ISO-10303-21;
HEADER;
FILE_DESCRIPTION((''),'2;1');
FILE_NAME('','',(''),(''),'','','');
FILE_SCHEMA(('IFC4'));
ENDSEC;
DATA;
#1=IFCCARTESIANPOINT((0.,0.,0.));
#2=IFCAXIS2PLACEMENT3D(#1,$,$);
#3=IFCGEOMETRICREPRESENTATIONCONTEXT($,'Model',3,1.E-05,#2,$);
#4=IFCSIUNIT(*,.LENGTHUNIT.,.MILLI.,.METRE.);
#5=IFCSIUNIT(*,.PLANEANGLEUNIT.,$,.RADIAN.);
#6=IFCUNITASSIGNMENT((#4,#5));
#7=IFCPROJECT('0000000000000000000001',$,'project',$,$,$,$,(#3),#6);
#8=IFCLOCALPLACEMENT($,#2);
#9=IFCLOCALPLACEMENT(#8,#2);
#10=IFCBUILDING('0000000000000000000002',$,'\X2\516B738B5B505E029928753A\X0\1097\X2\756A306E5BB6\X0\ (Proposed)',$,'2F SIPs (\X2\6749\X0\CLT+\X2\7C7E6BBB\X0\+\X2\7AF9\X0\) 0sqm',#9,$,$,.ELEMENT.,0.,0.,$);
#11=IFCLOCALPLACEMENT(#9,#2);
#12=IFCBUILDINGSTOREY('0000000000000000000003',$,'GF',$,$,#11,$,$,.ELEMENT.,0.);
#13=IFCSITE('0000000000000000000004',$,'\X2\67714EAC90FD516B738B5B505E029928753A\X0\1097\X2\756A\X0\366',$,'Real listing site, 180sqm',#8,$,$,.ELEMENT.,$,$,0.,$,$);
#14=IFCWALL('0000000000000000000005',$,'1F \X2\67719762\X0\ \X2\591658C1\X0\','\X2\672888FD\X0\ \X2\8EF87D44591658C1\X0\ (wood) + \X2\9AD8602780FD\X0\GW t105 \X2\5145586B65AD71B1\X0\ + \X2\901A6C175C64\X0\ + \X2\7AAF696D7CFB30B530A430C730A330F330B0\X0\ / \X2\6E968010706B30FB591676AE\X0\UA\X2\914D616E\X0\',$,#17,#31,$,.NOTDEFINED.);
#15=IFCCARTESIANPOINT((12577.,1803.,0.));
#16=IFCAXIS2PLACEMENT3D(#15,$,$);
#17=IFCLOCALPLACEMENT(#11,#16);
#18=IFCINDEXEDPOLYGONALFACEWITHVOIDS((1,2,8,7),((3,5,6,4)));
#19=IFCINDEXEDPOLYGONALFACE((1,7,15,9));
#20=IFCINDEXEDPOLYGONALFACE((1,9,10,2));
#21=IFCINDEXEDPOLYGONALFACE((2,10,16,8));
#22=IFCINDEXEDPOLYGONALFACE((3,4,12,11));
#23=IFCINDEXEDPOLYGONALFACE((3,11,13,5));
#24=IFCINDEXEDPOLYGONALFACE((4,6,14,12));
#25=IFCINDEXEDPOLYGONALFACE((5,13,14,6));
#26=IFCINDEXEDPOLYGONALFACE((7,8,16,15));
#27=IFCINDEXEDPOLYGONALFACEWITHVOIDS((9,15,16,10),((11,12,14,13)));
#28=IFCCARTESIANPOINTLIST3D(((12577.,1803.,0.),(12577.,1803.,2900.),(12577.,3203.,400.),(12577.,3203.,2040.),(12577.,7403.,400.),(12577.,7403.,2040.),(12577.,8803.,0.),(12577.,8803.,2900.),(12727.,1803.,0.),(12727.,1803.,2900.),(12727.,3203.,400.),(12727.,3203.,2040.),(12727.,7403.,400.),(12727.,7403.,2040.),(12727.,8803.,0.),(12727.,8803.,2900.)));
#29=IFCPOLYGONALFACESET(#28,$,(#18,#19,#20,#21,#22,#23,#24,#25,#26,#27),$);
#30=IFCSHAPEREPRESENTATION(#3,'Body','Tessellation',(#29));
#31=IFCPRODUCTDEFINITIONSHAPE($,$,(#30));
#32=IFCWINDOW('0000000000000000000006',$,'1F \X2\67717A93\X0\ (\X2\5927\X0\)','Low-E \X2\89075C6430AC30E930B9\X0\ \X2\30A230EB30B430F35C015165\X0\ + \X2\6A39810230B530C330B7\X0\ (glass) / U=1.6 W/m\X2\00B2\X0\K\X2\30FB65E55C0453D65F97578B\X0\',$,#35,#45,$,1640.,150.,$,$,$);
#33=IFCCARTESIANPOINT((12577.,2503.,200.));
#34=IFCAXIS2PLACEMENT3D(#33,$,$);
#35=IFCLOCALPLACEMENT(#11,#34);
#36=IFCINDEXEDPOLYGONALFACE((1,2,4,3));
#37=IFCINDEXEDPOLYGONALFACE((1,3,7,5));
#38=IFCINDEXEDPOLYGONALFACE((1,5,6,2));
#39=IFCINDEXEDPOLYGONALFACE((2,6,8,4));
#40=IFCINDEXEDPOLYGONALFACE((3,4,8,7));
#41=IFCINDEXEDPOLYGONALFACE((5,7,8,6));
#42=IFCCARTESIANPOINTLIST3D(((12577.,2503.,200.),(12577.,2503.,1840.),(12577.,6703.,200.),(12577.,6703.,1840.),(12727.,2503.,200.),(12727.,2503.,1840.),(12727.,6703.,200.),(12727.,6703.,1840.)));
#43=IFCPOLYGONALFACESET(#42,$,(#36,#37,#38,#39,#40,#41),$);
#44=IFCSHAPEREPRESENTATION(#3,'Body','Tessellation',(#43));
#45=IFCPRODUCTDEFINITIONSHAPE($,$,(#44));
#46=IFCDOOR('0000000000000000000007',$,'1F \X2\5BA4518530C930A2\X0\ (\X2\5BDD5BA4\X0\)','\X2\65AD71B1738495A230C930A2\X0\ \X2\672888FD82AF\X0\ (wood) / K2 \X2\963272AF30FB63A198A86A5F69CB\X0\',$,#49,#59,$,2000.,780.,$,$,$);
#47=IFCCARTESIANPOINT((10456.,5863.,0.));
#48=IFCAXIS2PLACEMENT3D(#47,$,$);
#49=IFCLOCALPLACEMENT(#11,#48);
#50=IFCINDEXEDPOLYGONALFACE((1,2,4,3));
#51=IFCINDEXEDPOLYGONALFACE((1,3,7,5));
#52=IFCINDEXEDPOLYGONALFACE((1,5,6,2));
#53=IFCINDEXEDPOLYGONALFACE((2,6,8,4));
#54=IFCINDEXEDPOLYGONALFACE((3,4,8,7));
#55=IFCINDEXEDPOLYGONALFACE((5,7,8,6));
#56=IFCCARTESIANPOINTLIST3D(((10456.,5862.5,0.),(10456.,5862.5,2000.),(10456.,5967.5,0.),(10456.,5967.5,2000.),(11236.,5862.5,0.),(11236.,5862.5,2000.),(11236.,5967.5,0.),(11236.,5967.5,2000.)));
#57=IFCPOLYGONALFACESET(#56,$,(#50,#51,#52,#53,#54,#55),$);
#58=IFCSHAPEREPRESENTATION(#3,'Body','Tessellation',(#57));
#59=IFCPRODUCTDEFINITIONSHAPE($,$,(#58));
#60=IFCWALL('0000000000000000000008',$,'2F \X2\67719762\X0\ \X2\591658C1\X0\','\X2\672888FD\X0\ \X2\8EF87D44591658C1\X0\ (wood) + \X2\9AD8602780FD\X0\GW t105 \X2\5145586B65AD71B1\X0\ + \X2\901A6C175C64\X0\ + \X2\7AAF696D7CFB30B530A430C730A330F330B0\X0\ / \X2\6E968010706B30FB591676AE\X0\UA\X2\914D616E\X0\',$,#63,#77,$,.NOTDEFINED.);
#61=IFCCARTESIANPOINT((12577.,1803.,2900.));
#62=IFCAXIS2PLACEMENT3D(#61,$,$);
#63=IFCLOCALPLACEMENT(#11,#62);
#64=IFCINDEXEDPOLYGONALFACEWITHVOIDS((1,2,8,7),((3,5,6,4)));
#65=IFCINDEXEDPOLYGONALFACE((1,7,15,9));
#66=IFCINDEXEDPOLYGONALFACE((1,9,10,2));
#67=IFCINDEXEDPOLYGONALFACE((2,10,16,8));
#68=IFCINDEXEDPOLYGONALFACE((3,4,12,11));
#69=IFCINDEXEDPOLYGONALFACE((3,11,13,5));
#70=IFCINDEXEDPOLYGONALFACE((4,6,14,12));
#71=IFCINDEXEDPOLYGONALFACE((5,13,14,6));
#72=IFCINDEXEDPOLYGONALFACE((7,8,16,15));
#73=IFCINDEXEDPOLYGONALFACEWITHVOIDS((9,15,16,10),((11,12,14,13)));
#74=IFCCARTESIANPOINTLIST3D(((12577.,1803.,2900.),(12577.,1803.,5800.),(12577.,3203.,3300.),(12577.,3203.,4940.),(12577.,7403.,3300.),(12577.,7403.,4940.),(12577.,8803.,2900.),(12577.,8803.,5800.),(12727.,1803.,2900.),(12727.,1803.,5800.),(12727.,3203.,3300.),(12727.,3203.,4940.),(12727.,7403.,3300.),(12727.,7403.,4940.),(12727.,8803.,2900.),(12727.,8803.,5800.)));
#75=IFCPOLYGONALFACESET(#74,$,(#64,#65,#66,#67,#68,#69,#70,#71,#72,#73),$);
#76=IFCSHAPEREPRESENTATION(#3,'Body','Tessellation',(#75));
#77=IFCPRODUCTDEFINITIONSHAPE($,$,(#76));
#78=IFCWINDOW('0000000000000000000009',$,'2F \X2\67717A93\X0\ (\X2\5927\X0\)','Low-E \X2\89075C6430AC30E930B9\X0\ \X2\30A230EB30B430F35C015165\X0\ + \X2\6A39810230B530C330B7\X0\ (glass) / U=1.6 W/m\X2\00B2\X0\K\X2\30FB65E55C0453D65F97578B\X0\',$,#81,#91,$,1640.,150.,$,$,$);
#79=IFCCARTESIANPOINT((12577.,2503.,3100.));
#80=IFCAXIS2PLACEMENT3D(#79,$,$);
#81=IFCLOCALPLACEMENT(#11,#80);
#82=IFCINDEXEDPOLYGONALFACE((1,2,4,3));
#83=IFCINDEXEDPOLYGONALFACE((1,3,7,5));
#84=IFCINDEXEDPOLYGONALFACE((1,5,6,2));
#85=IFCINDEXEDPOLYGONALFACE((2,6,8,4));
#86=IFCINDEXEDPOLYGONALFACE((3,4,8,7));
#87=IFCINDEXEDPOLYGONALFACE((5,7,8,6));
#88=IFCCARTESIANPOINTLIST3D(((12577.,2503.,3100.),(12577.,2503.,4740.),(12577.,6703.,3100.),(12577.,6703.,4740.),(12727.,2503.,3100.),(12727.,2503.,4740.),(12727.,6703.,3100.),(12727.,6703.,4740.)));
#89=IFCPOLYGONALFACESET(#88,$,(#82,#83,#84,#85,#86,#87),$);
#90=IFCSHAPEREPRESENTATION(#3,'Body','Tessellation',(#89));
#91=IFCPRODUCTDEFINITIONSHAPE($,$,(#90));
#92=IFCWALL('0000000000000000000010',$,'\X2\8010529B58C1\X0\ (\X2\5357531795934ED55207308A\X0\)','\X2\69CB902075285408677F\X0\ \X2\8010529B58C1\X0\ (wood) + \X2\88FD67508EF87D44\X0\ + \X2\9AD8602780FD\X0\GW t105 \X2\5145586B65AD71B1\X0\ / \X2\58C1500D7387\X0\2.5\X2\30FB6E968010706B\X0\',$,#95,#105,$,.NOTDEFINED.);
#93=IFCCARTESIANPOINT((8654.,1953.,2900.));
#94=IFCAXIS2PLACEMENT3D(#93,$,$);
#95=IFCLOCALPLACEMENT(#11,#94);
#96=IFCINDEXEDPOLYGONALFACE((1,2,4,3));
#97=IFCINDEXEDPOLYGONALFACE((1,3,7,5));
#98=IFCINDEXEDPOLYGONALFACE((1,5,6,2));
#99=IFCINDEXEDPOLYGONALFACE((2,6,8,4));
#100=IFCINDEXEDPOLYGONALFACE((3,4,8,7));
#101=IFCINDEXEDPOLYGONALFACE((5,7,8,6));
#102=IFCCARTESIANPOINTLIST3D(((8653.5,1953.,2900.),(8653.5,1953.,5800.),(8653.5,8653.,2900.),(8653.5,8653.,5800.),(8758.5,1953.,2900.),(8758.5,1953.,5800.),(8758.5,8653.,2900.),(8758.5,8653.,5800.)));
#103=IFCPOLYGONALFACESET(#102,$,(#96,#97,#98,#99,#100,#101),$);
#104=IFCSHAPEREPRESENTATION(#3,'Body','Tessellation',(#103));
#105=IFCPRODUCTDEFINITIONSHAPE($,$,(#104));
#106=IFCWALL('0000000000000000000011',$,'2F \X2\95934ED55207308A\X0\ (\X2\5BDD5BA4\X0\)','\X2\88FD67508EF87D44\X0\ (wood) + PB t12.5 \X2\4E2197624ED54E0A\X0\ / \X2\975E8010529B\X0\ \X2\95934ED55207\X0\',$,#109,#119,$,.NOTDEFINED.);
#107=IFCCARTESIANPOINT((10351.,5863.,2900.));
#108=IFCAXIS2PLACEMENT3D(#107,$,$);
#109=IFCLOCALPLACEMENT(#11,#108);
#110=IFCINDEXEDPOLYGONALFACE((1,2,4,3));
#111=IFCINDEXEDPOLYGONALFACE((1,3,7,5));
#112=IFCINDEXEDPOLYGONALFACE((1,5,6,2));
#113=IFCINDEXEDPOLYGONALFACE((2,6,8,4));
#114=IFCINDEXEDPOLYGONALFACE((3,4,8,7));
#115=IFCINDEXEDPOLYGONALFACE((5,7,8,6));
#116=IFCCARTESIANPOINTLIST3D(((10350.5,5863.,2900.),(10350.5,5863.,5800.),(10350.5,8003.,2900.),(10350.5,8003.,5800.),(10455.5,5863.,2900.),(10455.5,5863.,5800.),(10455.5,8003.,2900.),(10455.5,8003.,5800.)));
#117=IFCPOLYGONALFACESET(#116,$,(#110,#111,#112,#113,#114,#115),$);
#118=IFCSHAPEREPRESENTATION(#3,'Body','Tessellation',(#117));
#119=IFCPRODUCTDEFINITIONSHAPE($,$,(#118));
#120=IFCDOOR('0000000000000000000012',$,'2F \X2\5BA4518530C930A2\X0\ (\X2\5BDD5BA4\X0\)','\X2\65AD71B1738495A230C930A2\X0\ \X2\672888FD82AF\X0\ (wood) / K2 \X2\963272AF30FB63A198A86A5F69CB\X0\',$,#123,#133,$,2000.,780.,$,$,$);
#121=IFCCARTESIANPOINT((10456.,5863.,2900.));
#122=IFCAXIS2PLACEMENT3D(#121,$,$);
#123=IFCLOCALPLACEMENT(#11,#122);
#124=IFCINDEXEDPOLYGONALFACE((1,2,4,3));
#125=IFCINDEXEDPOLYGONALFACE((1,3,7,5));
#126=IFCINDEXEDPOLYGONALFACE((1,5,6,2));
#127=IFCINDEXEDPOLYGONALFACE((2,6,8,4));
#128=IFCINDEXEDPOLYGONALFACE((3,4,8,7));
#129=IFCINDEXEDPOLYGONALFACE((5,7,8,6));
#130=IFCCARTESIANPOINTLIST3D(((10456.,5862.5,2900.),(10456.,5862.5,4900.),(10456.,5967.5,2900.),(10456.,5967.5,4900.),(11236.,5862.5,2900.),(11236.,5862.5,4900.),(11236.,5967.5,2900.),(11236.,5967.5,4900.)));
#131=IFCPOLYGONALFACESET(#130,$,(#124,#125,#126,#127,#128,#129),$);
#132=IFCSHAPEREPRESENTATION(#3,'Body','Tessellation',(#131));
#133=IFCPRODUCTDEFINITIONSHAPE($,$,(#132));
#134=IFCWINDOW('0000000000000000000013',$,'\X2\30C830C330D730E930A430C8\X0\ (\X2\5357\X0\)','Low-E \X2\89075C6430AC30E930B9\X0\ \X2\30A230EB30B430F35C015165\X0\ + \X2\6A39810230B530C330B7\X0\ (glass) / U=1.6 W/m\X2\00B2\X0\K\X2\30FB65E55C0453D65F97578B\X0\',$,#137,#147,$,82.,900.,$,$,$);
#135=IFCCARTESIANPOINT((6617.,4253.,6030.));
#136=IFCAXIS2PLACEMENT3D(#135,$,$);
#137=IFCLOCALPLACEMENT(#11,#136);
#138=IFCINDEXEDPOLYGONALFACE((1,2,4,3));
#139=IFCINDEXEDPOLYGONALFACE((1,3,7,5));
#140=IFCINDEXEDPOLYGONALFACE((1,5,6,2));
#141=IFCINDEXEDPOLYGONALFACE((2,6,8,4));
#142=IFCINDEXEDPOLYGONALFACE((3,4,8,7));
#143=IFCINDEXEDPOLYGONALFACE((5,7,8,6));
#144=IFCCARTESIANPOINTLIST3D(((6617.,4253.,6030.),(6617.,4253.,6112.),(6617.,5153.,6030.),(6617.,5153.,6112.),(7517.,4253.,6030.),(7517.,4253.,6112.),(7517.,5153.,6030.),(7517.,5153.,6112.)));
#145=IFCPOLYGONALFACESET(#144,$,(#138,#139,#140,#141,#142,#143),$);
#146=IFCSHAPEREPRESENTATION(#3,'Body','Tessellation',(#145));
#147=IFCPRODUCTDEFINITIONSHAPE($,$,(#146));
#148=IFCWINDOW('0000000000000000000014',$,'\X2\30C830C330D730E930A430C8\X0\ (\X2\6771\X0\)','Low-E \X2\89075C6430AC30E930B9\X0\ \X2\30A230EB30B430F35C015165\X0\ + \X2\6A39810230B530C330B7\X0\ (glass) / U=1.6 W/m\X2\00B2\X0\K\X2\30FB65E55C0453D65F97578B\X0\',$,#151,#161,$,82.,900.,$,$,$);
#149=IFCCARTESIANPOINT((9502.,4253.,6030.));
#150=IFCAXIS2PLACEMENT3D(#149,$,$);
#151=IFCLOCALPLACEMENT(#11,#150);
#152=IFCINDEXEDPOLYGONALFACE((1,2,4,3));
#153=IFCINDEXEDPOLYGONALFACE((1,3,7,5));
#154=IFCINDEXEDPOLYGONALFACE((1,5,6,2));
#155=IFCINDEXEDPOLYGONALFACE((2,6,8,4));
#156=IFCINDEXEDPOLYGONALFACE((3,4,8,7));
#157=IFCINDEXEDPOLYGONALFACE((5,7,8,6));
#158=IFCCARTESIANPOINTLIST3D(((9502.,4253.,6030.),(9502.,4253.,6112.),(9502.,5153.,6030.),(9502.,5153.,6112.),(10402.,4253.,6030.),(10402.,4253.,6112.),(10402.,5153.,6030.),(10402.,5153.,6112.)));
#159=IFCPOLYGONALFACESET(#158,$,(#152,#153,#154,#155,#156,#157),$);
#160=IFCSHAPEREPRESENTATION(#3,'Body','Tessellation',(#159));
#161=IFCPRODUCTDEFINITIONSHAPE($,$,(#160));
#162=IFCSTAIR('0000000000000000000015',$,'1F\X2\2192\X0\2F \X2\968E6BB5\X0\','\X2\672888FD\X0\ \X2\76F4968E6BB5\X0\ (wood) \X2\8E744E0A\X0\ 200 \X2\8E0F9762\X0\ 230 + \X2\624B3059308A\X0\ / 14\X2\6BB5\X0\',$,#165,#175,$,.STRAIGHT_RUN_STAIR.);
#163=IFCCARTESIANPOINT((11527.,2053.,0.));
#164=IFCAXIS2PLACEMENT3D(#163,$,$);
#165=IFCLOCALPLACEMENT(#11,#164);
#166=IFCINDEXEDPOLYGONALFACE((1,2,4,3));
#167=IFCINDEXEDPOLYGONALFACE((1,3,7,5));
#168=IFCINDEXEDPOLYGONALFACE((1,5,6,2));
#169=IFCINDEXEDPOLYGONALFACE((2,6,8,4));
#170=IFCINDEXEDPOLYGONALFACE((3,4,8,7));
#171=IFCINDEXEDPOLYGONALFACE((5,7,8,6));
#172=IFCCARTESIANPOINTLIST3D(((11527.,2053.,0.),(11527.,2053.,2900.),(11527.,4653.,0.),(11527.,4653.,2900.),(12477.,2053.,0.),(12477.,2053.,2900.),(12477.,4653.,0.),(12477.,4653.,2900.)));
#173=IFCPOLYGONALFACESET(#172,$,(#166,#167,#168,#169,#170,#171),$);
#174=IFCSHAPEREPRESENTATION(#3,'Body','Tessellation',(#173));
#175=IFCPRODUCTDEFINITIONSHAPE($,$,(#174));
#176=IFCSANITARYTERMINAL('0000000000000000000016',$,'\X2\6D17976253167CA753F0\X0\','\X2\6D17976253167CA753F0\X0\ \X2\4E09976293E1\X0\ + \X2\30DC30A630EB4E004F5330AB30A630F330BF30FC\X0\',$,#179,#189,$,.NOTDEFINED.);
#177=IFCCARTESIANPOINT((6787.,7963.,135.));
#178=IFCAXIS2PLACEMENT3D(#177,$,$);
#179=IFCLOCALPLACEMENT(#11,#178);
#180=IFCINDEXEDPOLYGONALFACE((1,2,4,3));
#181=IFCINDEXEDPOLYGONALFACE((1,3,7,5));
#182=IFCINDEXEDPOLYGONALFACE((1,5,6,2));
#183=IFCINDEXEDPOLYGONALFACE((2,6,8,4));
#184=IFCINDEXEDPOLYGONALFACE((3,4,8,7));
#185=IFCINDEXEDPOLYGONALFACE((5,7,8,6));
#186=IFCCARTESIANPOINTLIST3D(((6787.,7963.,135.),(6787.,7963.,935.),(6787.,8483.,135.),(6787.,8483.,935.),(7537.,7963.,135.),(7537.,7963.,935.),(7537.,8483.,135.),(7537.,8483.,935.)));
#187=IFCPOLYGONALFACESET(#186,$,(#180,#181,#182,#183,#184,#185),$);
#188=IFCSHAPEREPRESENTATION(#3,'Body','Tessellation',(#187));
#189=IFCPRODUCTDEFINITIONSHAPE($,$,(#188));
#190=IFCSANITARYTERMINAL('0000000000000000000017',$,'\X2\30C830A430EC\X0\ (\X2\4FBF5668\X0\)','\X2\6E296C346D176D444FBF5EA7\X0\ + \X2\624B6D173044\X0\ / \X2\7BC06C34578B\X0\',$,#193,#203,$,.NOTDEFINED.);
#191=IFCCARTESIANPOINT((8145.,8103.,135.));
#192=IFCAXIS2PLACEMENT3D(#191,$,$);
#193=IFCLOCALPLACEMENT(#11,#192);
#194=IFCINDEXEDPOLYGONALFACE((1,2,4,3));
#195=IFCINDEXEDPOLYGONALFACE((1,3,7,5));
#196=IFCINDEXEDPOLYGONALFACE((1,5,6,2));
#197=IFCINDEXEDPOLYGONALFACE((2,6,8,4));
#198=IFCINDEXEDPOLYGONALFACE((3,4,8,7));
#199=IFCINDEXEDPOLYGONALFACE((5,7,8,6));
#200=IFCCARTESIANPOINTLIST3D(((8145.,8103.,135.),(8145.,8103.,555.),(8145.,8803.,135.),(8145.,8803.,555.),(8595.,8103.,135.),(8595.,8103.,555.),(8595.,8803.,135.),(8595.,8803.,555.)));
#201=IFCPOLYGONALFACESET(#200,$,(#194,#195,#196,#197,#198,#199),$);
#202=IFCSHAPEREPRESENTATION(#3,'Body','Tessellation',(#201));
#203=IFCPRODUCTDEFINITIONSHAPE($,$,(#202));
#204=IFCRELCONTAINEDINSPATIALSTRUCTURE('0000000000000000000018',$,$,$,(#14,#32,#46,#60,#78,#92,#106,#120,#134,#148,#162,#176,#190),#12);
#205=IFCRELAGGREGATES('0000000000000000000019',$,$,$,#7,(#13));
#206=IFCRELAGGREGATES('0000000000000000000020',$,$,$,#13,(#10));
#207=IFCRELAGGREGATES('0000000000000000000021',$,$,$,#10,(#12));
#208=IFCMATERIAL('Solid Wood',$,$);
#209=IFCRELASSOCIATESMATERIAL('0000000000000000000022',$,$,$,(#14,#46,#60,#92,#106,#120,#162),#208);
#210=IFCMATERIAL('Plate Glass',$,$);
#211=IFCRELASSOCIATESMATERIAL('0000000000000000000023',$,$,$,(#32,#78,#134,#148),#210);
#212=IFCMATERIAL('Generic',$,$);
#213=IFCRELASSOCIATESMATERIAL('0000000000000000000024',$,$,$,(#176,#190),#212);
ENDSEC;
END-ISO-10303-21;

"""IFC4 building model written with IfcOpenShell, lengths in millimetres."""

from ifc_helpers import new_model, si_unit, frame, frame_2d, origin, place, context, project, spatial, rectangle, extrude, material, element, fill, save


model = new_model("IFC4")

# Units and contexts
model_context = context("Model", 3, precision=1e-05, world=origin())
ifc_project = project(units=[si_unit("LENGTHUNIT", "METRE", prefix="MILLI"), si_unit("PLANEANGLEUNIT", "RADIAN")], contexts=[model_context])

# Site, building, storey
site_placement = place(None, origin())
site = spatial("IfcSite", under=ifc_project, at=site_placement, Name="東京都八王子市館町1097番366", ObjectType="Real listing site, 180sqm", CompositionType="ELEMENT", RefElevation=0.0)
building_placement = place(site_placement, origin())
building = spatial("IfcBuilding", under=site, at=building_placement, Name="八王子市館町1097番の家 (Proposed)", ObjectType="2F SIPs (杉CLT+籾殻+竹) 0sqm", CompositionType="ELEMENT", ElevationOfRefHeight=0.0, ElevationOfTerrain=0.0)
storey_placement = place(building_placement, origin())
storey = spatial("IfcBuildingStorey", under=building, at=storey_placement, Name="GF", CompositionType="ELEMENT", Elevation=0.0)

# Wall, opening, window
ifc_material_1 = material(Name="Solid Wood")
wall_1_placement = place(storey_placement, frame((12577.0, 1803.0, 0.0)))
wall_1 = element("IfcWall", 1, at=wall_1_placement, inside=storey, material=ifc_material_1, Name="1F 東面 外壁", Description="木製 軸組外壁 (wood) + 高性能GW t105 充填断熱 + 通気層 + 窯業系サイディング / 準耐火・外皮UA配慮", PredefinedType="NOTDEFINED", context=model_context, shape_type="SweptSolid", body=[
    extrude(rectangle(XDim=150.0, YDim=7000.0, at=frame_2d((75.0, 3500.0))), frame((12577.0, 1803.0, 0.0)), (0.0, 0.0, 1.0), 2900.0),
])
opening_1_placement = place(storey_placement, frame((12577.0, 2503.0, 200.0)))
opening_1 = element("IfcOpeningElement", 2, at=opening_1_placement, cuts=wall_1, PredefinedType="NOTDEFINED", context=model_context, shape_type="SweptSolid", body=[
    extrude(rectangle(XDim=150.0, YDim=4200.0, at=frame_2d((75.0, 2100.0))), frame((12577.0, 2503.0, 200.0)), (0.0, 0.0, 1.0), 1640.0),
])
ifc_material_2 = material(Name="Plate Glass")
window_1_placement = place(storey_placement, frame((12577.0, 2503.0, 200.0)))
window_1 = element("IfcWindow", 3, at=window_1_placement, inside=storey, material=ifc_material_2, Name="1F 東窓 (大)", Description="Low-E 複層ガラス アルゴン封入 + 樹脂サッシ (glass) / U=1.6 W/m²K・日射取得型", OverallHeight=1640.0, OverallWidth=150.0, context=model_context, shape_type="SweptSolid", body=[
    extrude(rectangle(XDim=150.0, YDim=4200.0, at=frame_2d((75.0, 2100.0))), frame((12577.0, 2503.0, 200.0)), (0.0, 0.0, 1.0), 1640.0),
])
fill(opening_1, window_1)

# Door
door_1_placement = place(storey_placement, frame((10456.0, 5863.0, 0.0)))
element("IfcDoor", 4, at=door_1_placement, inside=storey, material=ifc_material_1, Name="1F 室内ドア (寝室)", Description="断熱玄関ドア 木製芯 (wood) / K2 防犯・採風機構", OverallHeight=2000.0, OverallWidth=780.0, context=model_context, shape_type="SweptSolid", body=[
    extrude(rectangle(XDim=780.0, YDim=105.0, at=frame_2d((390.0, 52.0))), frame((10456.0, 5863.0, 0.0)), (0.0, 0.0, 1.0), 2000.0),
])

# Wall, opening, window
wall_2_placement = place(storey_placement, frame((12577.0, 1803.0, 2900.0)))
wall_2 = element("IfcWall", 5, at=wall_2_placement, inside=storey, material=ifc_material_1, Name="2F 東面 外壁", Description="木製 軸組外壁 (wood) + 高性能GW t105 充填断熱 + 通気層 + 窯業系サイディング / 準耐火・外皮UA配慮", PredefinedType="NOTDEFINED", context=model_context, shape_type="SweptSolid", body=[
    extrude(rectangle(XDim=150.0, YDim=7000.0, at=frame_2d((75.0, 3500.0))), frame((12577.0, 1803.0, 2900.0)), (0.0, 0.0, 1.0), 2900.0),
])
opening_2_placement = place(storey_placement, frame((12577.0, 2503.0, 3100.0)))
opening_2 = element("IfcOpeningElement", 6, at=opening_2_placement, cuts=wall_2, PredefinedType="NOTDEFINED", context=model_context, shape_type="SweptSolid", body=[
    extrude(rectangle(XDim=150.0, YDim=4200.0, at=frame_2d((75.0, 2100.0))), frame((12577.0, 2503.0, 3100.0)), (0.0, 0.0, 1.0), 1640.0),
])
window_2_placement = place(storey_placement, frame((12577.0, 2503.0, 3100.0)))
window_2 = element("IfcWindow", 7, at=window_2_placement, inside=storey, material=ifc_material_2, Name="2F 東窓 (大)", Description="Low-E 複層ガラス アルゴン封入 + 樹脂サッシ (glass) / U=1.6 W/m²K・日射取得型", OverallHeight=1640.0, OverallWidth=150.0, context=model_context, shape_type="SweptSolid", body=[
    extrude(rectangle(XDim=150.0, YDim=4200.0, at=frame_2d((75.0, 2100.0))), frame((12577.0, 2503.0, 3100.0)), (0.0, 0.0, 1.0), 1640.0),
])
fill(opening_2, window_2)

# Walls
wall_3_placement = place(storey_placement, frame((8654.0, 1953.0, 2900.0)))
element("IfcWall", 8, at=wall_3_placement, inside=storey, material=ifc_material_1, Name="耐力壁 (南北間仕切り)", Description="構造用合板 耐力壁 (wood) + 製材軸組 + 高性能GW t105 充填断熱 / 壁倍率2.5・準耐火", PredefinedType="NOTDEFINED", context=model_context, shape_type="SweptSolid", body=[
    extrude(rectangle(XDim=105.0, YDim=6700.0, at=frame_2d((52.0, 3350.0))), frame((8654.0, 1953.0, 2900.0)), (0.0, 0.0, 1.0), 2900.0),
])
wall_4_placement = place(storey_placement, frame((10351.0, 5863.0, 2900.0)))
element("IfcWall", 9, at=wall_4_placement, inside=storey, material=ifc_material_1, Name="2F 間仕切り (寝室)", Description="製材軸組 (wood) + PB t12.5 両面仕上 / 非耐力 間仕切", PredefinedType="NOTDEFINED", context=model_context, shape_type="SweptSolid", body=[
    extrude(rectangle(XDim=105.0, YDim=2140.0, at=frame_2d((52.0, 1070.0))), frame((10351.0, 5863.0, 2900.0)), (0.0, 0.0, 1.0), 2900.0),
])

# Door
door_2_placement = place(storey_placement, frame((10456.0, 5863.0, 2900.0)))
element("IfcDoor", 10, at=door_2_placement, inside=storey, material=ifc_material_1, Name="2F 室内ドア (寝室)", Description="断熱玄関ドア 木製芯 (wood) / K2 防犯・採風機構", OverallHeight=2000.0, OverallWidth=780.0, context=model_context, shape_type="SweptSolid", body=[
    extrude(rectangle(XDim=780.0, YDim=105.0, at=frame_2d((390.0, 52.0))), frame((10456.0, 5863.0, 2900.0)), (0.0, 0.0, 1.0), 2000.0),
])

# Windows
window_3_placement = place(storey_placement, frame((6617.0, 4253.0, 6030.0)))
element("IfcWindow", 11, at=window_3_placement, inside=storey, material=ifc_material_2, Name="トップライト (南)", Description="Low-E 複層ガラス アルゴン封入 + 樹脂サッシ (glass) / U=1.6 W/m²K・日射取得型", OverallHeight=82.0, OverallWidth=900.0, context=model_context, shape_type="SweptSolid", body=[
    extrude(rectangle(XDim=900.0, YDim=900.0, at=frame_2d((450.0, 450.0))), frame((6617.0, 4253.0, 6030.0)), (0.0, 0.0, 1.0), 82.0),
])
window_4_placement = place(storey_placement, frame((9502.0, 4253.0, 6030.0)))
element("IfcWindow", 12, at=window_4_placement, inside=storey, material=ifc_material_2, Name="トップライト (東)", Description="Low-E 複層ガラス アルゴン封入 + 樹脂サッシ (glass) / U=1.6 W/m²K・日射取得型", OverallHeight=82.0, OverallWidth=900.0, context=model_context, shape_type="SweptSolid", body=[
    extrude(rectangle(XDim=900.0, YDim=900.0, at=frame_2d((450.0, 450.0))), frame((9502.0, 4253.0, 6030.0)), (0.0, 0.0, 1.0), 82.0),
])

# Stair
stair_placement = place(storey_placement, frame((11527.0, 2053.0, 0.0)))
element("IfcStair", 13, at=stair_placement, inside=storey, material=ifc_material_1, Name="1F→2F 階段", Description="木製 直階段 (wood) 蹴上 200 踏面 230 + 手すり / 14段", PredefinedType="STRAIGHT_RUN_STAIR", context=model_context, shape_type="SweptSolid", body=[
    extrude(rectangle(XDim=950.0, YDim=2600.0, at=frame_2d((475.0, 1300.0))), frame((11527.0, 2053.0, 0.0)), (0.0, 0.0, 1.0), 2900.0),
])

# Sanitary terminals
ifc_material_3 = material(Name="Generic")
sanitary_terminal_1_placement = place(storey_placement, frame((6787.0, 7963.0, 135.0)))
element("IfcSanitaryTerminal", 14, at=sanitary_terminal_1_placement, inside=storey, material=ifc_material_3, Name="洗面化粧台", Description="洗面化粧台 三面鏡 + ボウル一体カウンター", PredefinedType="NOTDEFINED", context=model_context, shape_type="SweptSolid", body=[
    extrude(rectangle(XDim=750.0, YDim=520.0, at=frame_2d((375.0, 260.0))), frame((6787.0, 7963.0, 135.0)), (0.0, 0.0, 1.0), 800.0),
])
sanitary_terminal_2_placement = place(storey_placement, frame((8145.0, 8103.0, 135.0)))
element("IfcSanitaryTerminal", 15, at=sanitary_terminal_2_placement, inside=storey, material=ifc_material_3, Name="トイレ (便器)", Description="温水洗浄便座 + 手洗い / 節水型", PredefinedType="NOTDEFINED", context=model_context, shape_type="SweptSolid", body=[
    extrude(rectangle(XDim=450.0, YDim=700.0, at=frame_2d((225.0, 350.0))), frame((8145.0, 8103.0, 135.0)), (0.0, 0.0, 1.0), 420.0),
])

save(model, "model.ifc")
